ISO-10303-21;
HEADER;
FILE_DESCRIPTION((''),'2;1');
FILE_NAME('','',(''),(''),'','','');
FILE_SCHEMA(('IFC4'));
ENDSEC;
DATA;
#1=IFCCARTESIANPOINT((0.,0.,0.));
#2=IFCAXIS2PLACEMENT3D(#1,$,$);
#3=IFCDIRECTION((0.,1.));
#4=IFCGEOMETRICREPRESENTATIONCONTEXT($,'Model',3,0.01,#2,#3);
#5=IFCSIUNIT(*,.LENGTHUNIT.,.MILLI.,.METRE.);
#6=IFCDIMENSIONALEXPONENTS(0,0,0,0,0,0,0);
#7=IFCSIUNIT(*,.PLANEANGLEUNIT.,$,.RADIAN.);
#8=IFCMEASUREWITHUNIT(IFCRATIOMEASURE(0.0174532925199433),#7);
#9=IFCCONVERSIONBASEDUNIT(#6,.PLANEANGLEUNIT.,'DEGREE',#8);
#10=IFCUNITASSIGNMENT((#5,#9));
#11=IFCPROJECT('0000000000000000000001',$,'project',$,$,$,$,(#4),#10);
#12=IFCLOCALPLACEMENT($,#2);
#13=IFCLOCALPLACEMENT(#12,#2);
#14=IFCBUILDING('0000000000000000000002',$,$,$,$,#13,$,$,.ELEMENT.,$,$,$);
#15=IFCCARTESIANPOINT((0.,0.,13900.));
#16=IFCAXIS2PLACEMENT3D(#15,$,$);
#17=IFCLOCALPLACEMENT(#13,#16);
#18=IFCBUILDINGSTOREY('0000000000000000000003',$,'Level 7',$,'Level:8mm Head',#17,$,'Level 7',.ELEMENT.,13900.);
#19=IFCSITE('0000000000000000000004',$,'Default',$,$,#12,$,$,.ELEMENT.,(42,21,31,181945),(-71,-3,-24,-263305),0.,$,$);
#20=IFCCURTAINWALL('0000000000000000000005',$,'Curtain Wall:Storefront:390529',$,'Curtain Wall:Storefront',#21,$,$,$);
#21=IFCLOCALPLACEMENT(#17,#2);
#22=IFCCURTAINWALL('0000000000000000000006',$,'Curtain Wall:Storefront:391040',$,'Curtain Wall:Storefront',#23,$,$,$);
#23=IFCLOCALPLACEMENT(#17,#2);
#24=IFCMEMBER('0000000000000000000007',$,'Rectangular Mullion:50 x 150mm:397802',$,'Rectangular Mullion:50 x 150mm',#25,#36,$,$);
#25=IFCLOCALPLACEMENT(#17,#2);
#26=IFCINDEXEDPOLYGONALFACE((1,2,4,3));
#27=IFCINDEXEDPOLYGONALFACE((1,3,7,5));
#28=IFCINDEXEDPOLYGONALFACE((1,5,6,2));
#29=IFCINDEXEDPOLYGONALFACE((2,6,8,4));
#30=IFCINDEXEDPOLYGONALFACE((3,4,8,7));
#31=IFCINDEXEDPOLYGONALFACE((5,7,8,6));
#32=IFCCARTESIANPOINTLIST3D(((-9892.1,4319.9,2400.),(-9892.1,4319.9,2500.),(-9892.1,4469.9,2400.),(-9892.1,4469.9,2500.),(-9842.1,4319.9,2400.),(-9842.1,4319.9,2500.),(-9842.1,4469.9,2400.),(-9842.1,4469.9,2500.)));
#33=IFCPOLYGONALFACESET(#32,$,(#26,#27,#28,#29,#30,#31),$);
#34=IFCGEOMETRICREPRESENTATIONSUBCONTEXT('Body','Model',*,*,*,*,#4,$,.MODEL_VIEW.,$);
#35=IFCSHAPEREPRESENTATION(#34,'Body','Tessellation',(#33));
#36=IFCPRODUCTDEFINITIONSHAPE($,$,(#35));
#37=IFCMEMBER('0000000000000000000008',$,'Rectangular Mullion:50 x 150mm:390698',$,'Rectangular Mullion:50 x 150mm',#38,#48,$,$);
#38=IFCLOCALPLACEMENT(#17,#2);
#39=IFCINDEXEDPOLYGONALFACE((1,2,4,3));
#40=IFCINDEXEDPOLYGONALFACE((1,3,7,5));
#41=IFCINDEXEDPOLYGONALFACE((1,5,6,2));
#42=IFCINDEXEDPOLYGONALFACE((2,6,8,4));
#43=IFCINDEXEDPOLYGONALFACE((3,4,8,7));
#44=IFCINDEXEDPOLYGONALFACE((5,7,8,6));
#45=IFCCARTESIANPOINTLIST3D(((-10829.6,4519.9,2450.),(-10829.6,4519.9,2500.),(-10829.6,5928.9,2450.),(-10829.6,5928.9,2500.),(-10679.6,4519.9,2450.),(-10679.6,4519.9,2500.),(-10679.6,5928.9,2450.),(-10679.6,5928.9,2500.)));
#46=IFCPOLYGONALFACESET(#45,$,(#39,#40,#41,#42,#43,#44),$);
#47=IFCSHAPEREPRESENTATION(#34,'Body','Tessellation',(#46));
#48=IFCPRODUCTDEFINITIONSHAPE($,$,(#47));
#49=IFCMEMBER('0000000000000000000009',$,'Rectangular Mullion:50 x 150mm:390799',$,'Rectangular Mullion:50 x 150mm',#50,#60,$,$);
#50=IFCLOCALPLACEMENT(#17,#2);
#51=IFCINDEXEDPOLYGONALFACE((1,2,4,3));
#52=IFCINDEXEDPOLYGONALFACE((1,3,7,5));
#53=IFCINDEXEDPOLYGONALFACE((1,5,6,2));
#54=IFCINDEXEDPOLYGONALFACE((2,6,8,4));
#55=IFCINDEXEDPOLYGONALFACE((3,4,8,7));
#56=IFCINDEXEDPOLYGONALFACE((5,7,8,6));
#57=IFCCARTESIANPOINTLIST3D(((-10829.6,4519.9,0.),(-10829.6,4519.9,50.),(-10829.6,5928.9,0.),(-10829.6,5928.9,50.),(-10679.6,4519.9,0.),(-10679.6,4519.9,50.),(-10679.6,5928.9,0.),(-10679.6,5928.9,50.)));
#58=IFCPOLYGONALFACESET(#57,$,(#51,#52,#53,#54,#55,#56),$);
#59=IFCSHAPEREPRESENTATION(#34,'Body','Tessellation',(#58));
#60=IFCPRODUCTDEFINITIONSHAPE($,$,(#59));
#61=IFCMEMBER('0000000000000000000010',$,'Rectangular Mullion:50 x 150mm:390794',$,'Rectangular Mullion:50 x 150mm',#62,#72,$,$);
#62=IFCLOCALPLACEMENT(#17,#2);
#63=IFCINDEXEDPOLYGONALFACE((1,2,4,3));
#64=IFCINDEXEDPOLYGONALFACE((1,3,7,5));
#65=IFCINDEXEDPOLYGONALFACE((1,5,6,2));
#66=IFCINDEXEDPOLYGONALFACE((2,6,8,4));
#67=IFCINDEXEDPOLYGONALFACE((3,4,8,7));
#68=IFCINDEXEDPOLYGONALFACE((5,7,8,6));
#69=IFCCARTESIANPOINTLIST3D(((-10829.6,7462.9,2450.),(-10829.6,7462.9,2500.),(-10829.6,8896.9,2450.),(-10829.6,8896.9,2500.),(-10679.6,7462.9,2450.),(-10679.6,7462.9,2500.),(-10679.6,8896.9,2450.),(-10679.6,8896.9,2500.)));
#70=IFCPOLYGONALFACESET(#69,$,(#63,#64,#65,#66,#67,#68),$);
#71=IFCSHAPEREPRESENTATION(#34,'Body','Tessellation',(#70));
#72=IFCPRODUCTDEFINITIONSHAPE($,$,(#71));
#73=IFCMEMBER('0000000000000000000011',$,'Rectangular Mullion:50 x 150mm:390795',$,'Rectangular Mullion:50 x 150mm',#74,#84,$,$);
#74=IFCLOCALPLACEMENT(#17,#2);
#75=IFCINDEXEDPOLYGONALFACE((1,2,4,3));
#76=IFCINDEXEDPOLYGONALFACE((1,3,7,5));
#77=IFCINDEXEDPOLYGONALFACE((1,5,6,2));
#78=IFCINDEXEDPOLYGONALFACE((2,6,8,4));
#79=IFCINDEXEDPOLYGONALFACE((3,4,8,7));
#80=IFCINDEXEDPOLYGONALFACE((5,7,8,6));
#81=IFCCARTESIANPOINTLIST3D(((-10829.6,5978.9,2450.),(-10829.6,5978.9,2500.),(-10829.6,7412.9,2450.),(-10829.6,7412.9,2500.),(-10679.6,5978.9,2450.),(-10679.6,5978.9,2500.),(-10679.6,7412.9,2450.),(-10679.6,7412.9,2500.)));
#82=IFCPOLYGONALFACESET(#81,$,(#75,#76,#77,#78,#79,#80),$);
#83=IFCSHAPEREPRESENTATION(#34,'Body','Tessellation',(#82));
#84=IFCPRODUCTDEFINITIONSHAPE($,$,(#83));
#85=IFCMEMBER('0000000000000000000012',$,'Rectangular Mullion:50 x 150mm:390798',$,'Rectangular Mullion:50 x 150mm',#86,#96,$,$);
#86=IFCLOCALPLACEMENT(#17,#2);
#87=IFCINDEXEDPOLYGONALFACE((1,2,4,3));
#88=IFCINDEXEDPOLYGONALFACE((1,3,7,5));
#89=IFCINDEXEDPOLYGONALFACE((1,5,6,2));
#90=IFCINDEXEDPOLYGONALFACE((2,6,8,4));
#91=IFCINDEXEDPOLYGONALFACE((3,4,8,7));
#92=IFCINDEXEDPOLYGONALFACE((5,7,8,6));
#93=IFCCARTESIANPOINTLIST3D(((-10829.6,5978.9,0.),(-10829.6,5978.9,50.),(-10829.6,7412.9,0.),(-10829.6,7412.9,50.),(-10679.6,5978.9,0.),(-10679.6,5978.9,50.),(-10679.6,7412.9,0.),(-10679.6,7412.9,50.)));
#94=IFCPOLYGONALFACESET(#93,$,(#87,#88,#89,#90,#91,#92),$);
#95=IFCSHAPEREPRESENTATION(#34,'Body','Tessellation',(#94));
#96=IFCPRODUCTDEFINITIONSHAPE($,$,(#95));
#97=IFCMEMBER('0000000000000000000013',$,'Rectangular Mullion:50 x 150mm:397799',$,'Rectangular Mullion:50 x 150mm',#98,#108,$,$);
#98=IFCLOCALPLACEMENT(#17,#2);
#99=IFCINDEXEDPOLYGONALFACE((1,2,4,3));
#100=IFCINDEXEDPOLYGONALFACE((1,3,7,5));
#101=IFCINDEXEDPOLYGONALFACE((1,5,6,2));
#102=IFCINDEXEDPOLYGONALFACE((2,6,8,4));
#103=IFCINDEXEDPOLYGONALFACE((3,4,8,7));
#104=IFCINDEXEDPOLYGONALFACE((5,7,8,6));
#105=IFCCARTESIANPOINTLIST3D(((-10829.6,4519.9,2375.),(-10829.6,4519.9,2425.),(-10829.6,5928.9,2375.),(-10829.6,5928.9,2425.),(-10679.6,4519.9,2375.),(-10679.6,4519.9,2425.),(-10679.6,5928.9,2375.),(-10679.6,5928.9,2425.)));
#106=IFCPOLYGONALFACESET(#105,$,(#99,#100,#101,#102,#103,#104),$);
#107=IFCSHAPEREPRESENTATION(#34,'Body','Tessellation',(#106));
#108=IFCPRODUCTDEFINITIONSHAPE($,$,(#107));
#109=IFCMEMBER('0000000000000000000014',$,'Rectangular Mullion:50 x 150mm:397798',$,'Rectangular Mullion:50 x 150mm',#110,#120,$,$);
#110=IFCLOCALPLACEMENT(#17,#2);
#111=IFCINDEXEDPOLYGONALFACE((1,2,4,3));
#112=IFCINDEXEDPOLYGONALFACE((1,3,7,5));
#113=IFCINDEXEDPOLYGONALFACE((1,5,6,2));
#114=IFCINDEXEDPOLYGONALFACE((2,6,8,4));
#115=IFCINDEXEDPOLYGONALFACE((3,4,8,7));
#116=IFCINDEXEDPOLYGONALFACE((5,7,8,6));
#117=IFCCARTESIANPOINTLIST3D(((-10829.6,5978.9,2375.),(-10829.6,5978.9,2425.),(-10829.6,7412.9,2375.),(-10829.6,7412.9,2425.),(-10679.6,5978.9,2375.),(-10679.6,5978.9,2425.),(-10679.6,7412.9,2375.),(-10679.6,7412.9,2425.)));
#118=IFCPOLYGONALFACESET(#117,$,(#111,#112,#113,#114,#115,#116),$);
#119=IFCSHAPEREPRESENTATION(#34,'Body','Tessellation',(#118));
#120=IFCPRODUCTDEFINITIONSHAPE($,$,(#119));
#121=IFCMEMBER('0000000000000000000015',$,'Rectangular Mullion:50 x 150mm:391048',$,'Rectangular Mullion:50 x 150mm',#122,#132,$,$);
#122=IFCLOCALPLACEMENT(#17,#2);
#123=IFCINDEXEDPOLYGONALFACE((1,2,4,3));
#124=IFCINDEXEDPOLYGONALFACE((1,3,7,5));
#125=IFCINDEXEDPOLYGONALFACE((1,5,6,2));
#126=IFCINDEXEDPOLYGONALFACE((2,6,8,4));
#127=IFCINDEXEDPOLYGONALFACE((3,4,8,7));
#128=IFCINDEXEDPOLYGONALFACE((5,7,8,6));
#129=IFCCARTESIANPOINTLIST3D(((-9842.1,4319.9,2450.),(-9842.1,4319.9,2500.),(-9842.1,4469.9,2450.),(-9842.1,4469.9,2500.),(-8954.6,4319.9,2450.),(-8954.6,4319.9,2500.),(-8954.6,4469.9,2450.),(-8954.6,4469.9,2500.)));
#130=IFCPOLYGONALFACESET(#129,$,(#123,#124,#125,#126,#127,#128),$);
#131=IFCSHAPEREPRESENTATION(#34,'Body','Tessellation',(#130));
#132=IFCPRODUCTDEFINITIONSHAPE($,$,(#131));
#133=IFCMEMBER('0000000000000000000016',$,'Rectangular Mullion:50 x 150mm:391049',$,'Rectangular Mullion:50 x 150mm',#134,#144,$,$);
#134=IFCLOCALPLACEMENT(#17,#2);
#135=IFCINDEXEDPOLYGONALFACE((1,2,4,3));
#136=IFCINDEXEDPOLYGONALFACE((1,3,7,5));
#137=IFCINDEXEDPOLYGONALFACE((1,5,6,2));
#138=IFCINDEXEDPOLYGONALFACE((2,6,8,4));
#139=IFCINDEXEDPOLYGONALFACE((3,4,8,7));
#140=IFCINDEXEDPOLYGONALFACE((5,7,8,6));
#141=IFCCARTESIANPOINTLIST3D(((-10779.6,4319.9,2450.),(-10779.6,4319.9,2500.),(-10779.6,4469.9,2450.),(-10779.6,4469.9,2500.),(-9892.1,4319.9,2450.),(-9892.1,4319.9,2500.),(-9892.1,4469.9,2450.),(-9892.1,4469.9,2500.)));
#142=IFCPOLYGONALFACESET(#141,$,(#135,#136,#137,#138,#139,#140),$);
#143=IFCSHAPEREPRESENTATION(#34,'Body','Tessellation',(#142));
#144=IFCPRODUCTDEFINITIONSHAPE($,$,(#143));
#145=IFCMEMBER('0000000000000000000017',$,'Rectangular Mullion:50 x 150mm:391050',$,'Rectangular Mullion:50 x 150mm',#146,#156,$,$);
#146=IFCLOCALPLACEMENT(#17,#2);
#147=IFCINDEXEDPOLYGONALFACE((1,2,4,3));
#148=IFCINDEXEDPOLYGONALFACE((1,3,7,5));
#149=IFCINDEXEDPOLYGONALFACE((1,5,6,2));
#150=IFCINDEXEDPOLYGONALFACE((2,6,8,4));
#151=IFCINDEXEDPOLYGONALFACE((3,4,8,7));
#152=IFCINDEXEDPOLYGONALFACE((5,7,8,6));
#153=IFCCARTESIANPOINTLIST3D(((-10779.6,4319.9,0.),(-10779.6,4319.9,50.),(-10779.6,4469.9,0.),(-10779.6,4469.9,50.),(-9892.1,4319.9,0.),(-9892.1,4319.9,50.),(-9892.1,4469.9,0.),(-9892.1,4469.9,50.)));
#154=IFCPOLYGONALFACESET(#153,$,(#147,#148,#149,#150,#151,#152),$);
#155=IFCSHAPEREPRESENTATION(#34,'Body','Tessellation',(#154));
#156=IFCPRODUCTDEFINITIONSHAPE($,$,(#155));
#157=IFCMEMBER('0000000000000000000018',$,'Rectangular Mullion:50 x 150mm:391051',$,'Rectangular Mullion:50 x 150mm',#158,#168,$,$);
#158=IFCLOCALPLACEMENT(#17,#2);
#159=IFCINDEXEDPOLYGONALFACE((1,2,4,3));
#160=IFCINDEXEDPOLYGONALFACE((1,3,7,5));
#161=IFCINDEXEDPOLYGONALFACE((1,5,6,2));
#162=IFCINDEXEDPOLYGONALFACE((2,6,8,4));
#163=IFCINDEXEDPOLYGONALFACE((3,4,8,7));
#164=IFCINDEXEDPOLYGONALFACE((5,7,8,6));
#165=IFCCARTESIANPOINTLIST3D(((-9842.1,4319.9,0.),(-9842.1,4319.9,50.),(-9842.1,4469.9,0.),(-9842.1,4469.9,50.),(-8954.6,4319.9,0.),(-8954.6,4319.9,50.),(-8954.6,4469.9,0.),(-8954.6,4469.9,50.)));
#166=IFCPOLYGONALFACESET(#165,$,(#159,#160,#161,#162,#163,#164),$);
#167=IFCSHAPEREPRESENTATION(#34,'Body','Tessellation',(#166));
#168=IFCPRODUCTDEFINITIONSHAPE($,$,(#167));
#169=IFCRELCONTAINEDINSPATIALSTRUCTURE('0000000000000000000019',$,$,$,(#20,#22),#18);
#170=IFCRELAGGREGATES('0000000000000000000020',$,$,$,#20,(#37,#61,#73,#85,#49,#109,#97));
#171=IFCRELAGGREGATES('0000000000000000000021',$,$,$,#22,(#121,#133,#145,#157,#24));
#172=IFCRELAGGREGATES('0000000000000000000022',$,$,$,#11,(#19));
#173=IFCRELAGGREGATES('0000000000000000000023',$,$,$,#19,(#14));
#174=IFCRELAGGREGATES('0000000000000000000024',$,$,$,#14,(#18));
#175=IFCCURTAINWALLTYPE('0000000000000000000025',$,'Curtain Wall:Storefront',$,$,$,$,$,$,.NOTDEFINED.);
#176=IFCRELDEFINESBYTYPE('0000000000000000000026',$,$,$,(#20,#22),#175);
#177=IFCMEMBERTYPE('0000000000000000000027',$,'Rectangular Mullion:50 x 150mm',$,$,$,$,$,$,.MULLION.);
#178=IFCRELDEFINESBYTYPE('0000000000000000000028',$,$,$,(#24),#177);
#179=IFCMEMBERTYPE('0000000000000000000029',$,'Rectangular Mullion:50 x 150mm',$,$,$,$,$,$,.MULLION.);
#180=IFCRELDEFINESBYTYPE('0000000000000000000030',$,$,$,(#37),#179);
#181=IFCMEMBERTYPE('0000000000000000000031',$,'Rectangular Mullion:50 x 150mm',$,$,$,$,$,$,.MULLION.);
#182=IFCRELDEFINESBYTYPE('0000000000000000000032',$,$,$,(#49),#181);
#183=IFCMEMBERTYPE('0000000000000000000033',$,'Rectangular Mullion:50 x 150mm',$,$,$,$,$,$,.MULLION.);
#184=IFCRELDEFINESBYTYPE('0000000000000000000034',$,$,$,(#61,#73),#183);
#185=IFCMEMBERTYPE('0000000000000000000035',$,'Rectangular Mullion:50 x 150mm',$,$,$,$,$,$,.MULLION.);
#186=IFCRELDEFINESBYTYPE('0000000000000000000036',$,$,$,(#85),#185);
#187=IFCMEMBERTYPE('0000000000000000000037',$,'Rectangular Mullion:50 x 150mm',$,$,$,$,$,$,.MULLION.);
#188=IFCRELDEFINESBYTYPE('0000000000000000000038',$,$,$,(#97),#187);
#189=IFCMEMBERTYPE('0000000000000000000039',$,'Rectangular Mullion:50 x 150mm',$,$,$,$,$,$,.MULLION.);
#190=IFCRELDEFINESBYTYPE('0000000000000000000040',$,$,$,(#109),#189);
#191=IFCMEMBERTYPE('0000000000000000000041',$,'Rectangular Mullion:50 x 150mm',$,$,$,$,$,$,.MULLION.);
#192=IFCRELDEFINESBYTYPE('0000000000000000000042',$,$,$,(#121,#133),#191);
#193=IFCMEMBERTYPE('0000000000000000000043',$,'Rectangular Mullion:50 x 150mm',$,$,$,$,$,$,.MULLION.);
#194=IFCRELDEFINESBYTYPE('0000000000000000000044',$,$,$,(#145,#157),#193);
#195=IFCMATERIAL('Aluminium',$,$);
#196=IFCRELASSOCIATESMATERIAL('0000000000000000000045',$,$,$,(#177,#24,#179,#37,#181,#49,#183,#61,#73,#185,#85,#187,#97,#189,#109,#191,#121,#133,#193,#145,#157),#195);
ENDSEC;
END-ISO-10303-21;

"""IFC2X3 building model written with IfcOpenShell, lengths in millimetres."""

from ifc_helpers import new_model, entity, si_unit, converted_unit, direction, frame, origin, origin_2d_with_axis, place, context, subcontext, project, spatial, rectangle, extrude, source, transform, mapped, material, type_object, type_shapes, element, aggregate, save


model = new_model("IFC2X3")

# Units and contexts
model_context = context("Model", 3, precision=0.01, world=origin(), true_north=direction((0.0, 1.0)))
body_context = subcontext(model_context, "Body", "Model", "MODEL_VIEW")
ifc_project = project(units=[si_unit("LENGTHUNIT", "METRE", prefix="MILLI"), converted_unit("PLANEANGLEUNIT", "DEGREE", entity("IfcRatioMeasure", 0.0174532925199433), si_unit("PLANEANGLEUNIT", "RADIAN"), dimensions=[0, 0, 0, 0, 0, 0, 0])], contexts=[model_context])

# Site, building, storey
site_placement = place(None, frame((0.0, 0.0, 0.0)))
site = spatial("IfcSite", under=ifc_project, at=site_placement, Name="Default", CompositionType="ELEMENT", RefLatitude=(42, 21, 31, 181945), RefLongitude=(-71, -3, -24, -263305), RefElevation=0.0)
building_placement = place(site_placement, origin())
building = spatial("IfcBuilding", under=site, at=building_placement, CompositionType="ELEMENT")
storey_placement = place(building_placement, frame((0.0, 0.0, 13900.0)))
storey = spatial("IfcBuildingStorey", under=building, at=storey_placement, Name="Level 7", ObjectType="Level:8mm Head", LongName="Level 7", CompositionType="ELEMENT", Elevation=13900.0)

# Curtain wall
curtain_wall_type = type_object("IfcCurtainWallType", Name="Curtain Wall:Storefront", PredefinedType="NOTDEFINED")
curtain_wall_1_placement = place(storey_placement, frame((0.0, 0.0, -13900.0)))
curtain_wall_1 = element("IfcCurtainWall", 1, at=curtain_wall_1_placement, inside=storey, type_object=curtain_wall_type, Name="Curtain Wall:Storefront:390529", ObjectType="Curtain Wall:Storefront")
ifc_material_1 = material(Name="Aluminium")

# Curtain wall
curtain_wall_2_placement = place(storey_placement, frame((0.0, 0.0, -13900.0)))
curtain_wall_2 = element("IfcCurtainWall", 2, at=curtain_wall_2_placement, inside=storey, type_object=curtain_wall_type, Name="Curtain Wall:Storefront:391040", ObjectType="Curtain Wall:Storefront")

# Members
member_type_1 = type_object("IfcMemberType", Name="Rectangular Mullion:50 x 150mm", PredefinedType="MULLION", material=ifc_material_1)
shared_shape_1 = source(origin(), body_context, "Body", "SweptSolid", [
    extrude(rectangle(XDim=150.0, YDim=50.0, at=origin_2d_with_axis()), frame((0.0, 0.0, -100.0), z_axis=(0.0, 0.0, 1.0), x_axis=(0.0, -1.0, 0.0)), (0.0, 0.0, 1.0), 100.0),
])
type_shapes(member_type_1, [shared_shape_1])
member_1_placement = place(storey_placement, frame((-9867.1, 4394.9, 2400.0), z_axis=(0.0, 0.0, -1.0), x_axis=(1.0, 0.0, 0.0)))
member_1 = element("IfcMember", 3, at=member_1_placement, type_object=member_type_1, material=ifc_material_1, Name="Rectangular Mullion:50 x 150mm:397802", ObjectType="Rectangular Mullion:50 x 150mm", context=body_context, shape_type="MappedRepresentation", body=[
    mapped(shared_shape_1, transform((0.0, 0.0, 0.0), scale=1.0)),
])
member_type_2 = type_object("IfcMemberType", Name="Rectangular Mullion:50 x 150mm", PredefinedType="MULLION", material=ifc_material_1)
shared_shape_2 = source(origin(), body_context, "Body", "SweptSolid", [
    extrude(rectangle(XDim=150.0, YDim=50.0, at=origin_2d_with_axis()), frame((-25.0, 0.0, -1409.0), z_axis=(0.0, 0.0, 1.0), x_axis=(0.0, -1.0, 0.0)), (0.0, 0.0, 1.0), 1409.0),
])
type_shapes(member_type_2, [shared_shape_2])
member_2_placement = place(storey_placement, frame((-10754.6, 4519.9, 2500.0), z_axis=(0.0, -1.0, 0.0), x_axis=(0.0, 0.0, 1.0)))
member_2 = element("IfcMember", 4, at=member_2_placement, type_object=member_type_2, material=ifc_material_1, Name="Rectangular Mullion:50 x 150mm:390698", ObjectType="Rectangular Mullion:50 x 150mm", context=body_context, shape_type="MappedRepresentation", body=[
    mapped(shared_shape_2, transform((0.0, 0.0, 0.0), scale=1.0)),
])
member_type_3 = type_object("IfcMemberType", Name="Rectangular Mullion:50 x 150mm", PredefinedType="MULLION", material=ifc_material_1)
shared_shape_3 = source(origin(), body_context, "Body", "SweptSolid", [
    extrude(rectangle(XDim=150.0, YDim=50.0, at=origin_2d_with_axis()), frame((-25.0, 0.0, -1409.0), z_axis=(0.0, 0.0, 1.0), x_axis=(0.0, -1.0, 0.0)), (0.0, 0.0, 1.0), 1409.0),
])
type_shapes(member_type_3, [shared_shape_3])
member_3_placement = place(storey_placement, frame((-10754.6, 5928.9, 0.0), z_axis=(0.0, 1.0, 0.0), x_axis=(0.0, 0.0, -1.0)))
member_3 = element("IfcMember", 5, at=member_3_placement, type_object=member_type_3, material=ifc_material_1, Name="Rectangular Mullion:50 x 150mm:390799", ObjectType="Rectangular Mullion:50 x 150mm", context=body_context, shape_type="MappedRepresentation", body=[
    mapped(shared_shape_3, transform((0.0, 0.0, 0.0), scale=1.0)),
])
member_type_4 = type_object("IfcMemberType", Name="Rectangular Mullion:50 x 150mm", PredefinedType="MULLION", material=ifc_material_1)
shared_shape_4 = source(origin(), body_context, "Body", "SweptSolid", [
    extrude(rectangle(XDim=150.0, YDim=50.0, at=origin_2d_with_axis()), frame((-25.0, 0.0, -1434.0), z_axis=(0.0, 0.0, 1.0), x_axis=(0.0, -1.0, 0.0)), (0.0, 0.0, 1.0), 1434.0),
])
type_shapes(member_type_4, [shared_shape_4])
member_4_placement = place(storey_placement, frame((-10754.6, 7462.9, 2500.0), z_axis=(0.0, -1.0, 0.0), x_axis=(0.0, 0.0, 1.0)))
member_4 = element("IfcMember", 6, at=member_4_placement, type_object=member_type_4, material=ifc_material_1, Name="Rectangular Mullion:50 x 150mm:390794", ObjectType="Rectangular Mullion:50 x 150mm", context=body_context, shape_type="MappedRepresentation", body=[
    mapped(shared_shape_4, transform((0.0, 0.0, 0.0), scale=1.0)),
])
member_5_placement = place(storey_placement, frame((-10754.6, 5978.9, 2500.0), z_axis=(0.0, -1.0, 0.0), x_axis=(0.0, 0.0, 1.0)))
member_5 = element("IfcMember", 7, at=member_5_placement, type_object=member_type_4, material=ifc_material_1, Name="Rectangular Mullion:50 x 150mm:390795", ObjectType="Rectangular Mullion:50 x 150mm", context=body_context, shape_type="MappedRepresentation", body=[
    mapped(shared_shape_4, transform((0.0, 0.0, 0.0), scale=1.0)),
])
member_type_5 = type_object("IfcMemberType", Name="Rectangular Mullion:50 x 150mm", PredefinedType="MULLION", material=ifc_material_1)
shared_shape_5 = source(origin(), body_context, "Body", "SweptSolid", [
    extrude(rectangle(XDim=150.0, YDim=50.0, at=origin_2d_with_axis()), frame((-25.0, 0.0, -1434.0), z_axis=(0.0, 0.0, 1.0), x_axis=(0.0, -1.0, 0.0)), (0.0, 0.0, 1.0), 1434.0),
])
type_shapes(member_type_5, [shared_shape_5])
member_6_placement = place(storey_placement, frame((-10754.6, 7412.9, 0.0), z_axis=(0.0, 1.0, 0.0), x_axis=(0.0, 0.0, -1.0)))
member_6 = element("IfcMember", 8, at=member_6_placement, type_object=member_type_5, material=ifc_material_1, Name="Rectangular Mullion:50 x 150mm:390798", ObjectType="Rectangular Mullion:50 x 150mm", context=body_context, shape_type="MappedRepresentation", body=[
    mapped(shared_shape_5, transform((0.0, 0.0, 0.0), scale=1.0)),
])
member_type_6 = type_object("IfcMemberType", Name="Rectangular Mullion:50 x 150mm", PredefinedType="MULLION", material=ifc_material_1)
shared_shape_6 = source(origin(), body_context, "Body", "SweptSolid", [
    extrude(rectangle(XDim=150.0, YDim=50.0, at=origin_2d_with_axis()), frame((0.0, 0.0, -1409.0), z_axis=(0.0, 0.0, 1.0), x_axis=(0.0, -1.0, 0.0)), (0.0, 0.0, 1.0), 1409.0),
])
type_shapes(member_type_6, [shared_shape_6])
member_7_placement = place(storey_placement, frame((-10754.6, 4519.9, 2400.0), z_axis=(0.0, -1.0, 0.0), x_axis=(0.0, 0.0, 1.0)))
member_7 = element("IfcMember", 9, at=member_7_placement, type_object=member_type_6, material=ifc_material_1, Name="Rectangular Mullion:50 x 150mm:397799", ObjectType="Rectangular Mullion:50 x 150mm", context=body_context, shape_type="MappedRepresentation", body=[
    mapped(shared_shape_6, transform((0.0, 0.0, 0.0), scale=1.0)),
])
member_type_7 = type_object("IfcMemberType", Name="Rectangular Mullion:50 x 150mm", PredefinedType="MULLION", material=ifc_material_1)
shared_shape_7 = source(origin(), body_context, "Body", "SweptSolid", [
    extrude(rectangle(XDim=150.0, YDim=50.0, at=origin_2d_with_axis()), frame((0.0, 0.0, -1434.0), z_axis=(0.0, 0.0, 1.0), x_axis=(0.0, -1.0, 0.0)), (0.0, 0.0, 1.0), 1434.0),
])
type_shapes(member_type_7, [shared_shape_7])
member_8_placement = place(storey_placement, frame((-10754.6, 5978.9, 2400.0), z_axis=(0.0, -1.0, 0.0), x_axis=(0.0, 0.0, 1.0)))
member_8 = element("IfcMember", 10, at=member_8_placement, type_object=member_type_7, material=ifc_material_1, Name="Rectangular Mullion:50 x 150mm:397798", ObjectType="Rectangular Mullion:50 x 150mm", context=body_context, shape_type="MappedRepresentation", body=[
    mapped(shared_shape_7, transform((0.0, 0.0, 0.0), scale=1.0)),
])
member_type_8 = type_object("IfcMemberType", Name="Rectangular Mullion:50 x 150mm", PredefinedType="MULLION", material=ifc_material_1)
shared_shape_8 = source(origin(), body_context, "Body", "SweptSolid", [
    extrude(rectangle(XDim=150.0, YDim=50.0, at=origin_2d_with_axis()), frame((-25.0, 0.0, -887.5), z_axis=(0.0, 0.0, 1.0), x_axis=(0.0, -1.0, 0.0)), (0.0, 0.0, 1.0), 887.5),
])
type_shapes(member_type_8, [shared_shape_8])
member_9_placement = place(building_placement, frame((-8954.6, 4394.9, 16400.0), z_axis=(1.0, 0.0, 0.0), x_axis=(0.0, 0.0, 1.0)))
member_9 = element("IfcMember", 11, at=member_9_placement, type_object=member_type_8, material=ifc_material_1, Name="Rectangular Mullion:50 x 150mm:391048", ObjectType="Rectangular Mullion:50 x 150mm", context=body_context, shape_type="MappedRepresentation", body=[
    mapped(shared_shape_8, transform((0.0, 0.0, 0.0), scale=1.0)),
])
member_10_placement = place(building_placement, frame((-9892.1, 4394.9, 16400.0), z_axis=(1.0, 0.0, 0.0), x_axis=(0.0, 0.0, 1.0)))
member_10 = element("IfcMember", 12, at=member_10_placement, type_object=member_type_8, material=ifc_material_1, Name="Rectangular Mullion:50 x 150mm:391049", ObjectType="Rectangular Mullion:50 x 150mm", context=body_context, shape_type="MappedRepresentation", body=[
    mapped(shared_shape_8, transform((0.0, 0.0, 0.0), scale=1.0)),
])
member_type_9 = type_object("IfcMemberType", Name="Rectangular Mullion:50 x 150mm", PredefinedType="MULLION", material=ifc_material_1)
shared_shape_9 = source(origin(), body_context, "Body", "SweptSolid", [
    extrude(rectangle(XDim=150.0, YDim=50.0, at=origin_2d_with_axis()), frame((-25.0, 0.0, -887.5), z_axis=(0.0, 0.0, 1.0), x_axis=(0.0, -1.0, 0.0)), (0.0, 0.0, 1.0), 887.5),
])
type_shapes(member_type_9, [shared_shape_9])
member_11_placement = place(building_placement, frame((-10779.6, 4394.9, 13900.0), z_axis=(-1.0, 0.0, 0.0), x_axis=(0.0, 0.0, -1.0)))
member_11 = element("IfcMember", 13, at=member_11_placement, type_object=member_type_9, material=ifc_material_1, Name="Rectangular Mullion:50 x 150mm:391050", ObjectType="Rectangular Mullion:50 x 150mm", context=body_context, shape_type="MappedRepresentation", body=[
    mapped(shared_shape_9, transform((0.0, 0.0, 0.0), scale=1.0)),
])
member_12_placement = place(building_placement, frame((-9842.1, 4394.9, 13900.0), z_axis=(-1.0, 0.0, 0.0), x_axis=(0.0, 0.0, -1.0)))
member_12 = element("IfcMember", 14, at=member_12_placement, type_object=member_type_9, material=ifc_material_1, Name="Rectangular Mullion:50 x 150mm:391051", ObjectType="Rectangular Mullion:50 x 150mm", context=body_context, shape_type="MappedRepresentation", body=[
    mapped(shared_shape_9, transform((0.0, 0.0, 0.0), scale=1.0)),
])

aggregate(curtain_wall_1, [member_2, member_4, member_5, member_6, member_3, member_8, member_7])
aggregate(curtain_wall_2, [member_9, member_10, member_11, member_12, member_1])

save(model, "model.ifc")
